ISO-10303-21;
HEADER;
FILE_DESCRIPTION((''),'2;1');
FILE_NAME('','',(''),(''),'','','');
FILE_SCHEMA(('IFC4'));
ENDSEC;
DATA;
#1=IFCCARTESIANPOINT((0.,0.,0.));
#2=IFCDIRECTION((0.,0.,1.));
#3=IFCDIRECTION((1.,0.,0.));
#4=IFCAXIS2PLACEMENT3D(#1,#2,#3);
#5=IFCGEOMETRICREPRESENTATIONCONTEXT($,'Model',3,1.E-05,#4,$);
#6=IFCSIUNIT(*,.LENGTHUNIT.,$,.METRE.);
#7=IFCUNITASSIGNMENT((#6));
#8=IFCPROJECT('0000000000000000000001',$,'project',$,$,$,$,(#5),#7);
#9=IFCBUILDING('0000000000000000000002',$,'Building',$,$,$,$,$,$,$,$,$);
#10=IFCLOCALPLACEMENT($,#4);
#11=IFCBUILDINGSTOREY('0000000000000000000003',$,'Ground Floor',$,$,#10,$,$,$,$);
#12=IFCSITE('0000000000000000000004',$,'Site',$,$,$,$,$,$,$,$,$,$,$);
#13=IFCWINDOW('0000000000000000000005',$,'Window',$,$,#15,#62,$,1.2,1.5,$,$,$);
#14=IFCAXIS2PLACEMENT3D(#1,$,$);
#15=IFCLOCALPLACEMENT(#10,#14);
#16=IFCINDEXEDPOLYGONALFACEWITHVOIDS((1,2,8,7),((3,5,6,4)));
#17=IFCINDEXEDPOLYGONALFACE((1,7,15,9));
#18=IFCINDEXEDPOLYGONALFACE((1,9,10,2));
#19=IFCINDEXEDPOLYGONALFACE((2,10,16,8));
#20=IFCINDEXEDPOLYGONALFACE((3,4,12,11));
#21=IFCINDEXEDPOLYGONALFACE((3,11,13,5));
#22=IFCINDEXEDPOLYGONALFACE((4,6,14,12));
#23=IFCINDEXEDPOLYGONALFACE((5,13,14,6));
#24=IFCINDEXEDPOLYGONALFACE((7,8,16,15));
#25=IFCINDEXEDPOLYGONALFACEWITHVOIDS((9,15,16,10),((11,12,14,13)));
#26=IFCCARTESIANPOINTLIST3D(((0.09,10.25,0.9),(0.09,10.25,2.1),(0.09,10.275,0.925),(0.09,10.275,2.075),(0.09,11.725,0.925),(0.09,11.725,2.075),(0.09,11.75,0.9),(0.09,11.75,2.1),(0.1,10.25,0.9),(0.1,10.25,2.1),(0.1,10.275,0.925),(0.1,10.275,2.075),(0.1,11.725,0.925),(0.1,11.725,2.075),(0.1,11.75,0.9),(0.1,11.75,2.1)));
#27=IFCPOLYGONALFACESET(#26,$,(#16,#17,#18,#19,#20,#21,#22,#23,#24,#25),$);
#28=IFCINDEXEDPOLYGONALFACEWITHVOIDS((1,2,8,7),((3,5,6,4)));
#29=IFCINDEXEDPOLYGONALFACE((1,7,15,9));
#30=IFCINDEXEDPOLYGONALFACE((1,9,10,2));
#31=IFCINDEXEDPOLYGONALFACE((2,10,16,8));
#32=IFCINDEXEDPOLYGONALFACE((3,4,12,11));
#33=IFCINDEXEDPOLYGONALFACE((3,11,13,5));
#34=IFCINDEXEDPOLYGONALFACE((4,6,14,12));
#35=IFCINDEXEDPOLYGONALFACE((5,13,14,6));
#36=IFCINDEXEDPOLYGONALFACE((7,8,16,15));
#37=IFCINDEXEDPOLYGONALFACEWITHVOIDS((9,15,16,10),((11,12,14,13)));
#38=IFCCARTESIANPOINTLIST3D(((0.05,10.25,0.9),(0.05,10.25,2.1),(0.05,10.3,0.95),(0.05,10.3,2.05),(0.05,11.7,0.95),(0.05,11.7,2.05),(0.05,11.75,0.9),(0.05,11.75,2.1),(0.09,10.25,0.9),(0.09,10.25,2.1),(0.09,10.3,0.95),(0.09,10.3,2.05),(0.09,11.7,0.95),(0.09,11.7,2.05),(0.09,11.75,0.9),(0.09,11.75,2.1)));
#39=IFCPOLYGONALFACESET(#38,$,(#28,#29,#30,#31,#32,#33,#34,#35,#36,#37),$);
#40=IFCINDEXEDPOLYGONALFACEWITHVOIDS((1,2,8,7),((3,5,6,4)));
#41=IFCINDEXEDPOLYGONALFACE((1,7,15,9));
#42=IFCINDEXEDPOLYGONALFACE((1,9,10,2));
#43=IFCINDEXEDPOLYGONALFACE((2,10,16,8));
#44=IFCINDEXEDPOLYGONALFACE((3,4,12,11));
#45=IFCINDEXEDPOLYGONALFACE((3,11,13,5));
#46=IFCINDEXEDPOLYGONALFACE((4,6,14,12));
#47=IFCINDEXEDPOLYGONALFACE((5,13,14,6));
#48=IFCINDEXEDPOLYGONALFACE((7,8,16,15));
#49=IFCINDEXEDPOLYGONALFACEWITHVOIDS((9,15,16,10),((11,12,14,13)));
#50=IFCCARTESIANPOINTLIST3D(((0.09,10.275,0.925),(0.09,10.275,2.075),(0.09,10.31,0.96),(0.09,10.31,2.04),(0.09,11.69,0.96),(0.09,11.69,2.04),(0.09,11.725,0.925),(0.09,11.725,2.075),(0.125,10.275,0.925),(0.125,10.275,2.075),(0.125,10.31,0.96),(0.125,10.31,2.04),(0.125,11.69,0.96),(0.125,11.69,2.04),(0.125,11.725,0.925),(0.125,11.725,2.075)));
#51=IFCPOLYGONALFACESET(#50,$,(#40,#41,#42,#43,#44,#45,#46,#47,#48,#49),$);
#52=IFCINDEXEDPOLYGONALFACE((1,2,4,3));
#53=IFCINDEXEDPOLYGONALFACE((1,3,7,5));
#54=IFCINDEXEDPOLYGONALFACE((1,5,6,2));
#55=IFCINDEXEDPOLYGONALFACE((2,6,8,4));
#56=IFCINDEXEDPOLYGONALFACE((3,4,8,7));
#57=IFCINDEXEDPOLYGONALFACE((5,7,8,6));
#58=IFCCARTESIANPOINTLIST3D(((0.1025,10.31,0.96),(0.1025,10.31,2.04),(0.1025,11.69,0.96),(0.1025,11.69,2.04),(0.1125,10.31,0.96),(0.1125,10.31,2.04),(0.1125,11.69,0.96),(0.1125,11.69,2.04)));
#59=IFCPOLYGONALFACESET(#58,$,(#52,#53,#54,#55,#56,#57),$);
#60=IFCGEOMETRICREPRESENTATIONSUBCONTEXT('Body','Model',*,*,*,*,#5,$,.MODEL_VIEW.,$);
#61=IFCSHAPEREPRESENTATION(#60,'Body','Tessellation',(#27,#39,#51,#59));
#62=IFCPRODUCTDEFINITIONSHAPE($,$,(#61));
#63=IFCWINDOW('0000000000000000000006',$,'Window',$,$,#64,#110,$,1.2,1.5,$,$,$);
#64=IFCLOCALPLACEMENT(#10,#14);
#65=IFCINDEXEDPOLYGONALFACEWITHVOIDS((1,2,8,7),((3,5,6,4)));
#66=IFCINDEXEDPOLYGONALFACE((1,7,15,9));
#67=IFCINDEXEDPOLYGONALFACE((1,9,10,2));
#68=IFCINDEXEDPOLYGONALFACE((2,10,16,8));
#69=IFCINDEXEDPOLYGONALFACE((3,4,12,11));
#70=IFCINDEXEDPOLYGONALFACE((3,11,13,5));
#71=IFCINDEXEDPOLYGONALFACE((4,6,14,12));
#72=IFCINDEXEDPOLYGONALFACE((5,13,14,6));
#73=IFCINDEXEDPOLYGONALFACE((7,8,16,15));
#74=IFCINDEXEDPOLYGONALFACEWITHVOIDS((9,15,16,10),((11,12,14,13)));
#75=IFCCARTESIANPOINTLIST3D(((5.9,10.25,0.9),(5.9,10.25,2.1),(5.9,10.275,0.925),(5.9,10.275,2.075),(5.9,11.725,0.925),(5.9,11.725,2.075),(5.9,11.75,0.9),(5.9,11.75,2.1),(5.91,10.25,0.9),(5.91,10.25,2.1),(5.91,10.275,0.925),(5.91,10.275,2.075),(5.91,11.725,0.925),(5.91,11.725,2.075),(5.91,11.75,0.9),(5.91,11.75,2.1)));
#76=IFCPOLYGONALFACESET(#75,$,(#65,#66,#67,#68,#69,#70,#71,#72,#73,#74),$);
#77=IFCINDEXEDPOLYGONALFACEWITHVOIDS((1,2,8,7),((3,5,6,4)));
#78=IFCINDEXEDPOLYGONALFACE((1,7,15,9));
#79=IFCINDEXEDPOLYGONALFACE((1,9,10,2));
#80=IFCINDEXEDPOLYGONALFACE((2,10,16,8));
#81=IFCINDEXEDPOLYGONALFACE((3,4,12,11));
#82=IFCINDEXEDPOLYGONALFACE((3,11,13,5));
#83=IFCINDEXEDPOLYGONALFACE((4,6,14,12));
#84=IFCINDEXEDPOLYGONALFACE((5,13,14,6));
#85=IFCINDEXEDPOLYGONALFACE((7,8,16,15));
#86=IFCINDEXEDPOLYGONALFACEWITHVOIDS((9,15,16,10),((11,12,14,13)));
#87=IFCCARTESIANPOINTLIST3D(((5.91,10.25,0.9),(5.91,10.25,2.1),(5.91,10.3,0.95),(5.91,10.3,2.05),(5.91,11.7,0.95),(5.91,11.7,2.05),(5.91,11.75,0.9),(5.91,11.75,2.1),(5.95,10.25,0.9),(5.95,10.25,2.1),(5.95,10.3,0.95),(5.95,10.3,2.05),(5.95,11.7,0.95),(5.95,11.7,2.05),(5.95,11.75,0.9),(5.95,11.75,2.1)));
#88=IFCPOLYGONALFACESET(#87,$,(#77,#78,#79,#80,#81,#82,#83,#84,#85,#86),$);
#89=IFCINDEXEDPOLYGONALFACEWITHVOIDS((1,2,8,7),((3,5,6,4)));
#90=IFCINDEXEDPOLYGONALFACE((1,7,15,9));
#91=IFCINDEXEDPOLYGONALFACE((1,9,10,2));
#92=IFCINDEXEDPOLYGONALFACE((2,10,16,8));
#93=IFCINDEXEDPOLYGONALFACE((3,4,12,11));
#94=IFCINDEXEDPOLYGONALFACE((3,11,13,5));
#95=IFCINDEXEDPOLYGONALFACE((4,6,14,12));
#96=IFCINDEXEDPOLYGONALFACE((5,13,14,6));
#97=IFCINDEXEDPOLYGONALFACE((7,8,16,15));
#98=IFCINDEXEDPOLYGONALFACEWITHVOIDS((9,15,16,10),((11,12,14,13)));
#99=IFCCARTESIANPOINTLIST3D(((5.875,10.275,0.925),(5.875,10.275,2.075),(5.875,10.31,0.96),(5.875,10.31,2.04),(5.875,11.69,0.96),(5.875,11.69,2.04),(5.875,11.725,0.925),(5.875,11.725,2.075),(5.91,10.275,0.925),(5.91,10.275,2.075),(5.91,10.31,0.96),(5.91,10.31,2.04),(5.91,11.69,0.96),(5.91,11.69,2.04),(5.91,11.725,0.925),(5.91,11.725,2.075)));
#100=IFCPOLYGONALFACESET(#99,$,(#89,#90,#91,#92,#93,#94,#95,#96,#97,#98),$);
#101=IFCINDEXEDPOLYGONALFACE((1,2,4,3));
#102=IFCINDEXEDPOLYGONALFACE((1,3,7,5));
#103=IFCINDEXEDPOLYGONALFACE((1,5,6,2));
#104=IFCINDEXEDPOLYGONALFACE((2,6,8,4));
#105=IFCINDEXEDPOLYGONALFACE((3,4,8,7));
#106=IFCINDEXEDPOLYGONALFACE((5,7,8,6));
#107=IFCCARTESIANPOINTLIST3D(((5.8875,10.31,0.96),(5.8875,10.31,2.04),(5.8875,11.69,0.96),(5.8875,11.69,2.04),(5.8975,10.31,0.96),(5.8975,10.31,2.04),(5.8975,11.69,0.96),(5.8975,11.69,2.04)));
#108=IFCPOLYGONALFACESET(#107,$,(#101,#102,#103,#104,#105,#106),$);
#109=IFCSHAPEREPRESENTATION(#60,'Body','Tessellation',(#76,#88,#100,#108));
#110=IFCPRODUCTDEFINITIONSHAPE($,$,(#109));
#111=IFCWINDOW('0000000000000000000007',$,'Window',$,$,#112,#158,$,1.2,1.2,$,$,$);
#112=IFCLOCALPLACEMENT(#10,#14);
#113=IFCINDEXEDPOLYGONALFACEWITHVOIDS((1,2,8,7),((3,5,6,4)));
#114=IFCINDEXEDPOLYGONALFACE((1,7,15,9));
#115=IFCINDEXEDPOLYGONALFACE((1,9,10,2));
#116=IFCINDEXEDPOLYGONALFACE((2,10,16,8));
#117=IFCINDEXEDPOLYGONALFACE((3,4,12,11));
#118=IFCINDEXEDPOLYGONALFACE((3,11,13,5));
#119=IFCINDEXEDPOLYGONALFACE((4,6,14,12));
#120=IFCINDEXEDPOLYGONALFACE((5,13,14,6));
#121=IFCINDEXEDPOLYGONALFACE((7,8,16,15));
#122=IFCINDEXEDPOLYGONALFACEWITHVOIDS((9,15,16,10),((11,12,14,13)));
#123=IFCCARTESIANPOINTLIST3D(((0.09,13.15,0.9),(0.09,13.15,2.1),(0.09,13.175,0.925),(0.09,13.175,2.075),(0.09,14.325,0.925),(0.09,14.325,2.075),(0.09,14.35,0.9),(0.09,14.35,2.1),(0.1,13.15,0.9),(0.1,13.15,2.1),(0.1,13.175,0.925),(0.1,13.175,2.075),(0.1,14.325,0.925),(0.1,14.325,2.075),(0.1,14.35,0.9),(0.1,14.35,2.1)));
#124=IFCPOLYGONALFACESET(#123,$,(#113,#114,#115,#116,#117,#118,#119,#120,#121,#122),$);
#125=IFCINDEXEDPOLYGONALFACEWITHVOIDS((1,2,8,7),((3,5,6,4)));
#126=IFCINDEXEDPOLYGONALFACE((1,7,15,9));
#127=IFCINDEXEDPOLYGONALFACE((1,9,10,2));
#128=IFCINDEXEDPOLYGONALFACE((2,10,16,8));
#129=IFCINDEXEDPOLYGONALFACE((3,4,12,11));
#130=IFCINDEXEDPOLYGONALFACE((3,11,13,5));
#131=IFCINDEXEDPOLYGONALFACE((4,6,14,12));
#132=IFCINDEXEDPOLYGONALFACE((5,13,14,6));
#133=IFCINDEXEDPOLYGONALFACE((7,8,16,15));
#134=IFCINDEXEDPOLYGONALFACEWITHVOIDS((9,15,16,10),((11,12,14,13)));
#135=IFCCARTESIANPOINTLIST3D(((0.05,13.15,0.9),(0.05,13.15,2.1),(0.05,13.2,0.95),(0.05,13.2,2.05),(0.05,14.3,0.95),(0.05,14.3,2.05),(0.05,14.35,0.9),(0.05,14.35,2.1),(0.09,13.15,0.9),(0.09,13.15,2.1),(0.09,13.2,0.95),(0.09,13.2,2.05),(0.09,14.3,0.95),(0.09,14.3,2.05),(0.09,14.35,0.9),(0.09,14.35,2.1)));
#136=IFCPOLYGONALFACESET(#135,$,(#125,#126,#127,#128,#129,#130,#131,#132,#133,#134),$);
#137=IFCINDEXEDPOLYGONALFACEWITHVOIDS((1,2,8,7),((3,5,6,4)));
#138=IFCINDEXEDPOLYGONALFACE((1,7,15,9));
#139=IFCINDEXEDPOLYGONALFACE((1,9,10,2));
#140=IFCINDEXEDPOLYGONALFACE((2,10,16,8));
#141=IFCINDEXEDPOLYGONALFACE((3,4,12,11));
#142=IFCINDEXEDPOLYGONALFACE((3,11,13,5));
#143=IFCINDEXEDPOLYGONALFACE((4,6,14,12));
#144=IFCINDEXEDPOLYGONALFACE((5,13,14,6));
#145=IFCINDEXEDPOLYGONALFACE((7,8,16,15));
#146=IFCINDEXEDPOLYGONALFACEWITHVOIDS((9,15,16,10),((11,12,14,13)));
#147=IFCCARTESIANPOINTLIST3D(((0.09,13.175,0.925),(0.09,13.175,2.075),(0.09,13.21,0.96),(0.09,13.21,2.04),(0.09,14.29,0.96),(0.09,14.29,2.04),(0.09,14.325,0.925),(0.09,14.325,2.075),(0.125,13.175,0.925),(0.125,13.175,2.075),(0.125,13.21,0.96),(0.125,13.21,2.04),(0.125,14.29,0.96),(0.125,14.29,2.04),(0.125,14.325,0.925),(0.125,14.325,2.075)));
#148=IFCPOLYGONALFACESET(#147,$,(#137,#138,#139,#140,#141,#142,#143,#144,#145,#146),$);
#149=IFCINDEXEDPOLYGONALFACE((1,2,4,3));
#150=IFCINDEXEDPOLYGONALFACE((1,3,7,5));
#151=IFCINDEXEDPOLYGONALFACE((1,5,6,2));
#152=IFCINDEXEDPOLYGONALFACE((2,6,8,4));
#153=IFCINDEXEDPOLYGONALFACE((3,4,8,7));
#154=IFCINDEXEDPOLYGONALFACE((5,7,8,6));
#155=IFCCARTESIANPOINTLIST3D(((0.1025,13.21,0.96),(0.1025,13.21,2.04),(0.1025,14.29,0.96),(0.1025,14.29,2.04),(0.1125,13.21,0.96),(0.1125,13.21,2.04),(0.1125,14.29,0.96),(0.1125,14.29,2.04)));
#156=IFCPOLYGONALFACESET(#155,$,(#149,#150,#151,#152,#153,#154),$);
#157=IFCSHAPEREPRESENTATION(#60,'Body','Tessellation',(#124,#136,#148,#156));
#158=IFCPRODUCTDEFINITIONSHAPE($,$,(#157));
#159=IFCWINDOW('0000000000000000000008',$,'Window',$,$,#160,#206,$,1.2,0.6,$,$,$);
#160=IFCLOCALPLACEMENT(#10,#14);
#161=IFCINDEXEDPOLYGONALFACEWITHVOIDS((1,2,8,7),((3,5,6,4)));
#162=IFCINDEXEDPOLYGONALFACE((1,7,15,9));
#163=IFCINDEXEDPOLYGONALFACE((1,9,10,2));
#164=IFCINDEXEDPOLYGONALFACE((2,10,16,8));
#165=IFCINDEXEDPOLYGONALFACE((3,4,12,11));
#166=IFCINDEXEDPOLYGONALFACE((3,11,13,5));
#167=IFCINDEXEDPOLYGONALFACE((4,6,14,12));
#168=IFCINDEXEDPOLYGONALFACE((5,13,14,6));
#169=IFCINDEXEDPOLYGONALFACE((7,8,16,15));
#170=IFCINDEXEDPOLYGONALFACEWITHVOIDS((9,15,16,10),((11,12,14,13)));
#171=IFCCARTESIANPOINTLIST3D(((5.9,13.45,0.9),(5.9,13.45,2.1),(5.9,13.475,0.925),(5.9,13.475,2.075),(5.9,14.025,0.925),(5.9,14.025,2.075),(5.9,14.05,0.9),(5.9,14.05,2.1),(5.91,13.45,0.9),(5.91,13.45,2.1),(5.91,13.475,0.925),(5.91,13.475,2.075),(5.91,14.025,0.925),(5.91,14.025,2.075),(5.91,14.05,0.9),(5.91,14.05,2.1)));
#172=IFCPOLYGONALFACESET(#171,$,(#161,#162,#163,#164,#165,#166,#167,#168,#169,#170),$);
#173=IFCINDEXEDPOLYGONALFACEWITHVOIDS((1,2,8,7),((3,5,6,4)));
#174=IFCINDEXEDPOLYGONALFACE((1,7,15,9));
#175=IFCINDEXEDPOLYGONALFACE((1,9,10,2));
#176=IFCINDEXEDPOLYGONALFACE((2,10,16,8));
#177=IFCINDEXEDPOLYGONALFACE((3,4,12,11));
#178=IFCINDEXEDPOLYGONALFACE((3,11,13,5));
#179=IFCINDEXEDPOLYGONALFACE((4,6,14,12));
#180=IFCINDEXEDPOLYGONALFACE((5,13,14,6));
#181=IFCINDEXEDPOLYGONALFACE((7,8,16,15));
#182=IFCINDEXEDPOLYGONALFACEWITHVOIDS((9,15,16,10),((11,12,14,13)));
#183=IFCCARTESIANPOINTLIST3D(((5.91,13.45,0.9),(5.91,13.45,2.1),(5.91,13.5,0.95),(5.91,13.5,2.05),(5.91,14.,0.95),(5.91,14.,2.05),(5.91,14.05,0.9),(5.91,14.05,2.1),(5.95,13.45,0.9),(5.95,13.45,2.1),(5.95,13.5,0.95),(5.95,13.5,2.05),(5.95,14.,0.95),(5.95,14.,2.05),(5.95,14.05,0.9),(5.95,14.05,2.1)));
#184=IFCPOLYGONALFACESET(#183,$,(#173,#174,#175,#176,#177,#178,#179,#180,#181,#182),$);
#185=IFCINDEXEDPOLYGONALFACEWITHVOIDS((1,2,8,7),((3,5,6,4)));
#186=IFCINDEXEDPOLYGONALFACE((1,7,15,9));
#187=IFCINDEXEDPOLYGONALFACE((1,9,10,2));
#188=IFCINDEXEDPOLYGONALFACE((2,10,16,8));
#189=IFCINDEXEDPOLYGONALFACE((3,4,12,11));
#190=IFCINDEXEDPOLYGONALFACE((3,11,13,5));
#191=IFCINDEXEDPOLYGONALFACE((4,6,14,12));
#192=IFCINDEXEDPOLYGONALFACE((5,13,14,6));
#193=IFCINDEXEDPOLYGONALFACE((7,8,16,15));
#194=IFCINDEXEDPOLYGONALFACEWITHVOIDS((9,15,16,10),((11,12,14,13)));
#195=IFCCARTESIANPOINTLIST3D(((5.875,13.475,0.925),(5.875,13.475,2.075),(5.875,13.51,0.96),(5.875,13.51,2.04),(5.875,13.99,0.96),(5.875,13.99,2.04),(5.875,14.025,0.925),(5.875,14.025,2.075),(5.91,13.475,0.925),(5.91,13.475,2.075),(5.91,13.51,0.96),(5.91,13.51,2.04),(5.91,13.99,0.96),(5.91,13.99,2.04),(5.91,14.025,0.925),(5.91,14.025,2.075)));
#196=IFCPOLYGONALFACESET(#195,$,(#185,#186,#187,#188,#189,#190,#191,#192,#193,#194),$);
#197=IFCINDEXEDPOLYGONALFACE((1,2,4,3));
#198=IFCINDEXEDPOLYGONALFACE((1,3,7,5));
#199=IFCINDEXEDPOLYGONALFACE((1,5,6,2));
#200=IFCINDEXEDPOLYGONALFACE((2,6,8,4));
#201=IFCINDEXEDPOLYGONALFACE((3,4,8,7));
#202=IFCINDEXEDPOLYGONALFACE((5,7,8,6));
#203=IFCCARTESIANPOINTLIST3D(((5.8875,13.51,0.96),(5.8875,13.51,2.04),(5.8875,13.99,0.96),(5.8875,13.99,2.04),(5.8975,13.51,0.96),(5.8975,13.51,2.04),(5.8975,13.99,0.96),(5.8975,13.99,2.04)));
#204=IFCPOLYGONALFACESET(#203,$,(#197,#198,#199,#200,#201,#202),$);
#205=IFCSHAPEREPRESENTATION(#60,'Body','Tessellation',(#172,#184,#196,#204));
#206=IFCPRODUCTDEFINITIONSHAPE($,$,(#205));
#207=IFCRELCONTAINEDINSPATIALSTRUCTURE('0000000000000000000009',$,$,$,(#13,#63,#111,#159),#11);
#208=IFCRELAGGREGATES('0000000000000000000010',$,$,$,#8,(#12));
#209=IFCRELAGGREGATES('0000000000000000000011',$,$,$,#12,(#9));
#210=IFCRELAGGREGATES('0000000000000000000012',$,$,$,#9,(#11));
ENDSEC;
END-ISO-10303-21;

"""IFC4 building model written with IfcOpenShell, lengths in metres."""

from ifc_helpers import new_model, si_unit, frame, origin_with_axes, place, context, subcontext, project, spatial, line, indexed_curve, outline, extrude, element, save


model = new_model("IFC4")

# Units and contexts
model_context = context("Model", 3, precision=1e-05, world=origin_with_axes())
body_context = subcontext(model_context, "Body", "Model", "MODEL_VIEW")
ifc_project = project(units=[si_unit("LENGTHUNIT", "METRE")], contexts=[model_context])

# Site, building, storey
site = spatial("IfcSite", under=ifc_project, Name="Site")
building = spatial("IfcBuilding", under=site, Name="Building")
storey_placement = place(None, origin_with_axes())
storey = spatial("IfcBuildingStorey", under=building, at=storey_placement, Name="Ground Floor")

# Windows
for number, where, z_axis, x_axis, name in (
    (1, (0.0, 11.75, 0.9), (0.0, 0.0, 1.0), (0.0, -1.0, 0.0), "Window"),
    (2, (6.0, 10.25, 0.9), (0.0, 0.0, 1.0), (0.0, 1.0, 0.0), "Window"),
):
    element("IfcWindow", number, at=place(storey_placement, frame(where, z_axis=z_axis, x_axis=x_axis)), inside=storey, Name=name, OverallHeight=1.2, OverallWidth=1.5, context=body_context, shape_type="SweptSolid", body=[
        extrude(outline(indexed_curve([(0.0, 0.0), (1.5, 0.0), (1.5, 1.2), (0.0, 1.2)], segments=[line(1, 2, 3, 4, 1)]), holes=[indexed_curve([(0.025, 0.025), (1.475, 0.025), (1.475, 1.175), (0.025, 1.175)], segments=[line(1, 2, 3, 4, 1)])]), frame((0.0, 0.09, 0.0), z_axis=(0.0, -1.0, 0.0), x_axis=(1.0, 0.0, 0.0)), (0.0, 0.0, -1.0), 0.01),
        extrude(outline(indexed_curve([(0.0, 0.0), (1.5, 0.0), (1.5, 1.2), (0.0, 1.2)], segments=[line(1, 2, 3, 4, 1)]), holes=[indexed_curve([(0.05, 0.05), (1.45, 0.05), (1.45, 1.15), (0.05, 1.15)], segments=[line(1, 2, 3, 4, 1)])]), frame((0.0, 0.05, 0.0), z_axis=(0.0, -1.0, 0.0), x_axis=(1.0, 0.0, 0.0)), (0.0, 0.0, -1.0), 0.04),
        extrude(outline(indexed_curve([(0.0, 0.0), (1.45, 0.0), (1.45, 1.15), (0.0, 1.15)], segments=[line(1, 2, 3, 4, 1)]), holes=[indexed_curve([(0.035, 0.035), (1.415, 0.035), (1.415, 1.115), (0.035, 1.115)], segments=[line(1, 2, 3, 4, 1)])]), frame((0.025, 0.09, 0.025), z_axis=(0.0, -1.0, 0.0), x_axis=(1.0, 0.0, 0.0)), (0.0, 0.0, -1.0), 0.035),
        extrude(outline(indexed_curve([(0.035, 0.035), (1.415, 0.035), (1.415, 1.115), (0.035, 1.115)], segments=[line(1, 2, 3, 4, 1)])), frame((0.025, 0.1025, 0.025), z_axis=(0.0, -1.0, 0.0), x_axis=(1.0, 0.0, 0.0)), (0.0, 0.0, -1.0), 0.01),
    ])
window_1_placement = place(storey_placement, frame((0.0, 14.35, 0.9), z_axis=(0.0, 0.0, 1.0), x_axis=(0.0, -1.0, 0.0)))
element("IfcWindow", 3, at=window_1_placement, inside=storey, Name="Window", OverallHeight=1.2, OverallWidth=1.2, context=body_context, shape_type="SweptSolid", body=[
    extrude(outline(indexed_curve([(0.0, 0.0), (1.2, 0.0), (1.2, 1.2), (0.0, 1.2)], segments=[line(1, 2, 3, 4, 1)]), holes=[indexed_curve([(0.025, 0.025), (1.175, 0.025), (1.175, 1.175), (0.025, 1.175)], segments=[line(1, 2, 3, 4, 1)])]), frame((0.0, 0.09, 0.0), z_axis=(0.0, -1.0, 0.0), x_axis=(1.0, 0.0, 0.0)), (0.0, 0.0, -1.0), 0.01),
    extrude(outline(indexed_curve([(0.0, 0.0), (1.2, 0.0), (1.2, 1.2), (0.0, 1.2)], segments=[line(1, 2, 3, 4, 1)]), holes=[indexed_curve([(0.05, 0.05), (1.15, 0.05), (1.15, 1.15), (0.05, 1.15)], segments=[line(1, 2, 3, 4, 1)])]), frame((0.0, 0.05, 0.0), z_axis=(0.0, -1.0, 0.0), x_axis=(1.0, 0.0, 0.0)), (0.0, 0.0, -1.0), 0.04),
    extrude(outline(indexed_curve([(0.0, 0.0), (1.15, 0.0), (1.15, 1.15), (0.0, 1.15)], segments=[line(1, 2, 3, 4, 1)]), holes=[indexed_curve([(0.035, 0.035), (1.115, 0.035), (1.115, 1.115), (0.035, 1.115)], segments=[line(1, 2, 3, 4, 1)])]), frame((0.025, 0.09, 0.025), z_axis=(0.0, -1.0, 0.0), x_axis=(1.0, 0.0, 0.0)), (0.0, 0.0, -1.0), 0.035),
    extrude(outline(indexed_curve([(0.035, 0.035), (1.115, 0.035), (1.115, 1.115), (0.035, 1.115)], segments=[line(1, 2, 3, 4, 1)])), frame((0.025, 0.1025, 0.025), z_axis=(0.0, -1.0, 0.0), x_axis=(1.0, 0.0, 0.0)), (0.0, 0.0, -1.0), 0.01),
])
window_2_placement = place(storey_placement, frame((6.0, 13.45, 0.9), z_axis=(0.0, 0.0, 1.0), x_axis=(0.0, 1.0, 0.0)))
element("IfcWindow", 4, at=window_2_placement, inside=storey, Name="Window", OverallHeight=1.2, OverallWidth=0.6, context=body_context, shape_type="SweptSolid", body=[
    extrude(outline(indexed_curve([(0.0, 0.0), (0.6, 0.0), (0.6, 1.2), (0.0, 1.2)], segments=[line(1, 2, 3, 4, 1)]), holes=[indexed_curve([(0.025, 0.025), (0.575, 0.025), (0.575, 1.175), (0.025, 1.175)], segments=[line(1, 2, 3, 4, 1)])]), frame((0.0, 0.09, 0.0), z_axis=(0.0, -1.0, 0.0), x_axis=(1.0, 0.0, 0.0)), (0.0, 0.0, -1.0), 0.01),
    extrude(outline(indexed_curve([(0.0, 0.0), (0.6, 0.0), (0.6, 1.2), (0.0, 1.2)], segments=[line(1, 2, 3, 4, 1)]), holes=[indexed_curve([(0.05, 0.05), (0.55, 0.05), (0.55, 1.15), (0.05, 1.15)], segments=[line(1, 2, 3, 4, 1)])]), frame((0.0, 0.05, 0.0), z_axis=(0.0, -1.0, 0.0), x_axis=(1.0, 0.0, 0.0)), (0.0, 0.0, -1.0), 0.04),
    extrude(outline(indexed_curve([(0.0, 0.0), (0.55, 0.0), (0.55, 1.15), (0.0, 1.15)], segments=[line(1, 2, 3, 4, 1)]), holes=[indexed_curve([(0.035, 0.035), (0.515, 0.035), (0.515, 1.115), (0.035, 1.115)], segments=[line(1, 2, 3, 4, 1)])]), frame((0.025, 0.09, 0.025), z_axis=(0.0, -1.0, 0.0), x_axis=(1.0, 0.0, 0.0)), (0.0, 0.0, -1.0), 0.035),
    extrude(outline(indexed_curve([(0.035, 0.035), (0.515, 0.035), (0.515, 1.115), (0.035, 1.115)], segments=[line(1, 2, 3, 4, 1)])), frame((0.025, 0.1025, 0.025), z_axis=(0.0, -1.0, 0.0), x_axis=(1.0, 0.0, 0.0)), (0.0, 0.0, -1.0), 0.01),
])

save(model, "model.ifc")
